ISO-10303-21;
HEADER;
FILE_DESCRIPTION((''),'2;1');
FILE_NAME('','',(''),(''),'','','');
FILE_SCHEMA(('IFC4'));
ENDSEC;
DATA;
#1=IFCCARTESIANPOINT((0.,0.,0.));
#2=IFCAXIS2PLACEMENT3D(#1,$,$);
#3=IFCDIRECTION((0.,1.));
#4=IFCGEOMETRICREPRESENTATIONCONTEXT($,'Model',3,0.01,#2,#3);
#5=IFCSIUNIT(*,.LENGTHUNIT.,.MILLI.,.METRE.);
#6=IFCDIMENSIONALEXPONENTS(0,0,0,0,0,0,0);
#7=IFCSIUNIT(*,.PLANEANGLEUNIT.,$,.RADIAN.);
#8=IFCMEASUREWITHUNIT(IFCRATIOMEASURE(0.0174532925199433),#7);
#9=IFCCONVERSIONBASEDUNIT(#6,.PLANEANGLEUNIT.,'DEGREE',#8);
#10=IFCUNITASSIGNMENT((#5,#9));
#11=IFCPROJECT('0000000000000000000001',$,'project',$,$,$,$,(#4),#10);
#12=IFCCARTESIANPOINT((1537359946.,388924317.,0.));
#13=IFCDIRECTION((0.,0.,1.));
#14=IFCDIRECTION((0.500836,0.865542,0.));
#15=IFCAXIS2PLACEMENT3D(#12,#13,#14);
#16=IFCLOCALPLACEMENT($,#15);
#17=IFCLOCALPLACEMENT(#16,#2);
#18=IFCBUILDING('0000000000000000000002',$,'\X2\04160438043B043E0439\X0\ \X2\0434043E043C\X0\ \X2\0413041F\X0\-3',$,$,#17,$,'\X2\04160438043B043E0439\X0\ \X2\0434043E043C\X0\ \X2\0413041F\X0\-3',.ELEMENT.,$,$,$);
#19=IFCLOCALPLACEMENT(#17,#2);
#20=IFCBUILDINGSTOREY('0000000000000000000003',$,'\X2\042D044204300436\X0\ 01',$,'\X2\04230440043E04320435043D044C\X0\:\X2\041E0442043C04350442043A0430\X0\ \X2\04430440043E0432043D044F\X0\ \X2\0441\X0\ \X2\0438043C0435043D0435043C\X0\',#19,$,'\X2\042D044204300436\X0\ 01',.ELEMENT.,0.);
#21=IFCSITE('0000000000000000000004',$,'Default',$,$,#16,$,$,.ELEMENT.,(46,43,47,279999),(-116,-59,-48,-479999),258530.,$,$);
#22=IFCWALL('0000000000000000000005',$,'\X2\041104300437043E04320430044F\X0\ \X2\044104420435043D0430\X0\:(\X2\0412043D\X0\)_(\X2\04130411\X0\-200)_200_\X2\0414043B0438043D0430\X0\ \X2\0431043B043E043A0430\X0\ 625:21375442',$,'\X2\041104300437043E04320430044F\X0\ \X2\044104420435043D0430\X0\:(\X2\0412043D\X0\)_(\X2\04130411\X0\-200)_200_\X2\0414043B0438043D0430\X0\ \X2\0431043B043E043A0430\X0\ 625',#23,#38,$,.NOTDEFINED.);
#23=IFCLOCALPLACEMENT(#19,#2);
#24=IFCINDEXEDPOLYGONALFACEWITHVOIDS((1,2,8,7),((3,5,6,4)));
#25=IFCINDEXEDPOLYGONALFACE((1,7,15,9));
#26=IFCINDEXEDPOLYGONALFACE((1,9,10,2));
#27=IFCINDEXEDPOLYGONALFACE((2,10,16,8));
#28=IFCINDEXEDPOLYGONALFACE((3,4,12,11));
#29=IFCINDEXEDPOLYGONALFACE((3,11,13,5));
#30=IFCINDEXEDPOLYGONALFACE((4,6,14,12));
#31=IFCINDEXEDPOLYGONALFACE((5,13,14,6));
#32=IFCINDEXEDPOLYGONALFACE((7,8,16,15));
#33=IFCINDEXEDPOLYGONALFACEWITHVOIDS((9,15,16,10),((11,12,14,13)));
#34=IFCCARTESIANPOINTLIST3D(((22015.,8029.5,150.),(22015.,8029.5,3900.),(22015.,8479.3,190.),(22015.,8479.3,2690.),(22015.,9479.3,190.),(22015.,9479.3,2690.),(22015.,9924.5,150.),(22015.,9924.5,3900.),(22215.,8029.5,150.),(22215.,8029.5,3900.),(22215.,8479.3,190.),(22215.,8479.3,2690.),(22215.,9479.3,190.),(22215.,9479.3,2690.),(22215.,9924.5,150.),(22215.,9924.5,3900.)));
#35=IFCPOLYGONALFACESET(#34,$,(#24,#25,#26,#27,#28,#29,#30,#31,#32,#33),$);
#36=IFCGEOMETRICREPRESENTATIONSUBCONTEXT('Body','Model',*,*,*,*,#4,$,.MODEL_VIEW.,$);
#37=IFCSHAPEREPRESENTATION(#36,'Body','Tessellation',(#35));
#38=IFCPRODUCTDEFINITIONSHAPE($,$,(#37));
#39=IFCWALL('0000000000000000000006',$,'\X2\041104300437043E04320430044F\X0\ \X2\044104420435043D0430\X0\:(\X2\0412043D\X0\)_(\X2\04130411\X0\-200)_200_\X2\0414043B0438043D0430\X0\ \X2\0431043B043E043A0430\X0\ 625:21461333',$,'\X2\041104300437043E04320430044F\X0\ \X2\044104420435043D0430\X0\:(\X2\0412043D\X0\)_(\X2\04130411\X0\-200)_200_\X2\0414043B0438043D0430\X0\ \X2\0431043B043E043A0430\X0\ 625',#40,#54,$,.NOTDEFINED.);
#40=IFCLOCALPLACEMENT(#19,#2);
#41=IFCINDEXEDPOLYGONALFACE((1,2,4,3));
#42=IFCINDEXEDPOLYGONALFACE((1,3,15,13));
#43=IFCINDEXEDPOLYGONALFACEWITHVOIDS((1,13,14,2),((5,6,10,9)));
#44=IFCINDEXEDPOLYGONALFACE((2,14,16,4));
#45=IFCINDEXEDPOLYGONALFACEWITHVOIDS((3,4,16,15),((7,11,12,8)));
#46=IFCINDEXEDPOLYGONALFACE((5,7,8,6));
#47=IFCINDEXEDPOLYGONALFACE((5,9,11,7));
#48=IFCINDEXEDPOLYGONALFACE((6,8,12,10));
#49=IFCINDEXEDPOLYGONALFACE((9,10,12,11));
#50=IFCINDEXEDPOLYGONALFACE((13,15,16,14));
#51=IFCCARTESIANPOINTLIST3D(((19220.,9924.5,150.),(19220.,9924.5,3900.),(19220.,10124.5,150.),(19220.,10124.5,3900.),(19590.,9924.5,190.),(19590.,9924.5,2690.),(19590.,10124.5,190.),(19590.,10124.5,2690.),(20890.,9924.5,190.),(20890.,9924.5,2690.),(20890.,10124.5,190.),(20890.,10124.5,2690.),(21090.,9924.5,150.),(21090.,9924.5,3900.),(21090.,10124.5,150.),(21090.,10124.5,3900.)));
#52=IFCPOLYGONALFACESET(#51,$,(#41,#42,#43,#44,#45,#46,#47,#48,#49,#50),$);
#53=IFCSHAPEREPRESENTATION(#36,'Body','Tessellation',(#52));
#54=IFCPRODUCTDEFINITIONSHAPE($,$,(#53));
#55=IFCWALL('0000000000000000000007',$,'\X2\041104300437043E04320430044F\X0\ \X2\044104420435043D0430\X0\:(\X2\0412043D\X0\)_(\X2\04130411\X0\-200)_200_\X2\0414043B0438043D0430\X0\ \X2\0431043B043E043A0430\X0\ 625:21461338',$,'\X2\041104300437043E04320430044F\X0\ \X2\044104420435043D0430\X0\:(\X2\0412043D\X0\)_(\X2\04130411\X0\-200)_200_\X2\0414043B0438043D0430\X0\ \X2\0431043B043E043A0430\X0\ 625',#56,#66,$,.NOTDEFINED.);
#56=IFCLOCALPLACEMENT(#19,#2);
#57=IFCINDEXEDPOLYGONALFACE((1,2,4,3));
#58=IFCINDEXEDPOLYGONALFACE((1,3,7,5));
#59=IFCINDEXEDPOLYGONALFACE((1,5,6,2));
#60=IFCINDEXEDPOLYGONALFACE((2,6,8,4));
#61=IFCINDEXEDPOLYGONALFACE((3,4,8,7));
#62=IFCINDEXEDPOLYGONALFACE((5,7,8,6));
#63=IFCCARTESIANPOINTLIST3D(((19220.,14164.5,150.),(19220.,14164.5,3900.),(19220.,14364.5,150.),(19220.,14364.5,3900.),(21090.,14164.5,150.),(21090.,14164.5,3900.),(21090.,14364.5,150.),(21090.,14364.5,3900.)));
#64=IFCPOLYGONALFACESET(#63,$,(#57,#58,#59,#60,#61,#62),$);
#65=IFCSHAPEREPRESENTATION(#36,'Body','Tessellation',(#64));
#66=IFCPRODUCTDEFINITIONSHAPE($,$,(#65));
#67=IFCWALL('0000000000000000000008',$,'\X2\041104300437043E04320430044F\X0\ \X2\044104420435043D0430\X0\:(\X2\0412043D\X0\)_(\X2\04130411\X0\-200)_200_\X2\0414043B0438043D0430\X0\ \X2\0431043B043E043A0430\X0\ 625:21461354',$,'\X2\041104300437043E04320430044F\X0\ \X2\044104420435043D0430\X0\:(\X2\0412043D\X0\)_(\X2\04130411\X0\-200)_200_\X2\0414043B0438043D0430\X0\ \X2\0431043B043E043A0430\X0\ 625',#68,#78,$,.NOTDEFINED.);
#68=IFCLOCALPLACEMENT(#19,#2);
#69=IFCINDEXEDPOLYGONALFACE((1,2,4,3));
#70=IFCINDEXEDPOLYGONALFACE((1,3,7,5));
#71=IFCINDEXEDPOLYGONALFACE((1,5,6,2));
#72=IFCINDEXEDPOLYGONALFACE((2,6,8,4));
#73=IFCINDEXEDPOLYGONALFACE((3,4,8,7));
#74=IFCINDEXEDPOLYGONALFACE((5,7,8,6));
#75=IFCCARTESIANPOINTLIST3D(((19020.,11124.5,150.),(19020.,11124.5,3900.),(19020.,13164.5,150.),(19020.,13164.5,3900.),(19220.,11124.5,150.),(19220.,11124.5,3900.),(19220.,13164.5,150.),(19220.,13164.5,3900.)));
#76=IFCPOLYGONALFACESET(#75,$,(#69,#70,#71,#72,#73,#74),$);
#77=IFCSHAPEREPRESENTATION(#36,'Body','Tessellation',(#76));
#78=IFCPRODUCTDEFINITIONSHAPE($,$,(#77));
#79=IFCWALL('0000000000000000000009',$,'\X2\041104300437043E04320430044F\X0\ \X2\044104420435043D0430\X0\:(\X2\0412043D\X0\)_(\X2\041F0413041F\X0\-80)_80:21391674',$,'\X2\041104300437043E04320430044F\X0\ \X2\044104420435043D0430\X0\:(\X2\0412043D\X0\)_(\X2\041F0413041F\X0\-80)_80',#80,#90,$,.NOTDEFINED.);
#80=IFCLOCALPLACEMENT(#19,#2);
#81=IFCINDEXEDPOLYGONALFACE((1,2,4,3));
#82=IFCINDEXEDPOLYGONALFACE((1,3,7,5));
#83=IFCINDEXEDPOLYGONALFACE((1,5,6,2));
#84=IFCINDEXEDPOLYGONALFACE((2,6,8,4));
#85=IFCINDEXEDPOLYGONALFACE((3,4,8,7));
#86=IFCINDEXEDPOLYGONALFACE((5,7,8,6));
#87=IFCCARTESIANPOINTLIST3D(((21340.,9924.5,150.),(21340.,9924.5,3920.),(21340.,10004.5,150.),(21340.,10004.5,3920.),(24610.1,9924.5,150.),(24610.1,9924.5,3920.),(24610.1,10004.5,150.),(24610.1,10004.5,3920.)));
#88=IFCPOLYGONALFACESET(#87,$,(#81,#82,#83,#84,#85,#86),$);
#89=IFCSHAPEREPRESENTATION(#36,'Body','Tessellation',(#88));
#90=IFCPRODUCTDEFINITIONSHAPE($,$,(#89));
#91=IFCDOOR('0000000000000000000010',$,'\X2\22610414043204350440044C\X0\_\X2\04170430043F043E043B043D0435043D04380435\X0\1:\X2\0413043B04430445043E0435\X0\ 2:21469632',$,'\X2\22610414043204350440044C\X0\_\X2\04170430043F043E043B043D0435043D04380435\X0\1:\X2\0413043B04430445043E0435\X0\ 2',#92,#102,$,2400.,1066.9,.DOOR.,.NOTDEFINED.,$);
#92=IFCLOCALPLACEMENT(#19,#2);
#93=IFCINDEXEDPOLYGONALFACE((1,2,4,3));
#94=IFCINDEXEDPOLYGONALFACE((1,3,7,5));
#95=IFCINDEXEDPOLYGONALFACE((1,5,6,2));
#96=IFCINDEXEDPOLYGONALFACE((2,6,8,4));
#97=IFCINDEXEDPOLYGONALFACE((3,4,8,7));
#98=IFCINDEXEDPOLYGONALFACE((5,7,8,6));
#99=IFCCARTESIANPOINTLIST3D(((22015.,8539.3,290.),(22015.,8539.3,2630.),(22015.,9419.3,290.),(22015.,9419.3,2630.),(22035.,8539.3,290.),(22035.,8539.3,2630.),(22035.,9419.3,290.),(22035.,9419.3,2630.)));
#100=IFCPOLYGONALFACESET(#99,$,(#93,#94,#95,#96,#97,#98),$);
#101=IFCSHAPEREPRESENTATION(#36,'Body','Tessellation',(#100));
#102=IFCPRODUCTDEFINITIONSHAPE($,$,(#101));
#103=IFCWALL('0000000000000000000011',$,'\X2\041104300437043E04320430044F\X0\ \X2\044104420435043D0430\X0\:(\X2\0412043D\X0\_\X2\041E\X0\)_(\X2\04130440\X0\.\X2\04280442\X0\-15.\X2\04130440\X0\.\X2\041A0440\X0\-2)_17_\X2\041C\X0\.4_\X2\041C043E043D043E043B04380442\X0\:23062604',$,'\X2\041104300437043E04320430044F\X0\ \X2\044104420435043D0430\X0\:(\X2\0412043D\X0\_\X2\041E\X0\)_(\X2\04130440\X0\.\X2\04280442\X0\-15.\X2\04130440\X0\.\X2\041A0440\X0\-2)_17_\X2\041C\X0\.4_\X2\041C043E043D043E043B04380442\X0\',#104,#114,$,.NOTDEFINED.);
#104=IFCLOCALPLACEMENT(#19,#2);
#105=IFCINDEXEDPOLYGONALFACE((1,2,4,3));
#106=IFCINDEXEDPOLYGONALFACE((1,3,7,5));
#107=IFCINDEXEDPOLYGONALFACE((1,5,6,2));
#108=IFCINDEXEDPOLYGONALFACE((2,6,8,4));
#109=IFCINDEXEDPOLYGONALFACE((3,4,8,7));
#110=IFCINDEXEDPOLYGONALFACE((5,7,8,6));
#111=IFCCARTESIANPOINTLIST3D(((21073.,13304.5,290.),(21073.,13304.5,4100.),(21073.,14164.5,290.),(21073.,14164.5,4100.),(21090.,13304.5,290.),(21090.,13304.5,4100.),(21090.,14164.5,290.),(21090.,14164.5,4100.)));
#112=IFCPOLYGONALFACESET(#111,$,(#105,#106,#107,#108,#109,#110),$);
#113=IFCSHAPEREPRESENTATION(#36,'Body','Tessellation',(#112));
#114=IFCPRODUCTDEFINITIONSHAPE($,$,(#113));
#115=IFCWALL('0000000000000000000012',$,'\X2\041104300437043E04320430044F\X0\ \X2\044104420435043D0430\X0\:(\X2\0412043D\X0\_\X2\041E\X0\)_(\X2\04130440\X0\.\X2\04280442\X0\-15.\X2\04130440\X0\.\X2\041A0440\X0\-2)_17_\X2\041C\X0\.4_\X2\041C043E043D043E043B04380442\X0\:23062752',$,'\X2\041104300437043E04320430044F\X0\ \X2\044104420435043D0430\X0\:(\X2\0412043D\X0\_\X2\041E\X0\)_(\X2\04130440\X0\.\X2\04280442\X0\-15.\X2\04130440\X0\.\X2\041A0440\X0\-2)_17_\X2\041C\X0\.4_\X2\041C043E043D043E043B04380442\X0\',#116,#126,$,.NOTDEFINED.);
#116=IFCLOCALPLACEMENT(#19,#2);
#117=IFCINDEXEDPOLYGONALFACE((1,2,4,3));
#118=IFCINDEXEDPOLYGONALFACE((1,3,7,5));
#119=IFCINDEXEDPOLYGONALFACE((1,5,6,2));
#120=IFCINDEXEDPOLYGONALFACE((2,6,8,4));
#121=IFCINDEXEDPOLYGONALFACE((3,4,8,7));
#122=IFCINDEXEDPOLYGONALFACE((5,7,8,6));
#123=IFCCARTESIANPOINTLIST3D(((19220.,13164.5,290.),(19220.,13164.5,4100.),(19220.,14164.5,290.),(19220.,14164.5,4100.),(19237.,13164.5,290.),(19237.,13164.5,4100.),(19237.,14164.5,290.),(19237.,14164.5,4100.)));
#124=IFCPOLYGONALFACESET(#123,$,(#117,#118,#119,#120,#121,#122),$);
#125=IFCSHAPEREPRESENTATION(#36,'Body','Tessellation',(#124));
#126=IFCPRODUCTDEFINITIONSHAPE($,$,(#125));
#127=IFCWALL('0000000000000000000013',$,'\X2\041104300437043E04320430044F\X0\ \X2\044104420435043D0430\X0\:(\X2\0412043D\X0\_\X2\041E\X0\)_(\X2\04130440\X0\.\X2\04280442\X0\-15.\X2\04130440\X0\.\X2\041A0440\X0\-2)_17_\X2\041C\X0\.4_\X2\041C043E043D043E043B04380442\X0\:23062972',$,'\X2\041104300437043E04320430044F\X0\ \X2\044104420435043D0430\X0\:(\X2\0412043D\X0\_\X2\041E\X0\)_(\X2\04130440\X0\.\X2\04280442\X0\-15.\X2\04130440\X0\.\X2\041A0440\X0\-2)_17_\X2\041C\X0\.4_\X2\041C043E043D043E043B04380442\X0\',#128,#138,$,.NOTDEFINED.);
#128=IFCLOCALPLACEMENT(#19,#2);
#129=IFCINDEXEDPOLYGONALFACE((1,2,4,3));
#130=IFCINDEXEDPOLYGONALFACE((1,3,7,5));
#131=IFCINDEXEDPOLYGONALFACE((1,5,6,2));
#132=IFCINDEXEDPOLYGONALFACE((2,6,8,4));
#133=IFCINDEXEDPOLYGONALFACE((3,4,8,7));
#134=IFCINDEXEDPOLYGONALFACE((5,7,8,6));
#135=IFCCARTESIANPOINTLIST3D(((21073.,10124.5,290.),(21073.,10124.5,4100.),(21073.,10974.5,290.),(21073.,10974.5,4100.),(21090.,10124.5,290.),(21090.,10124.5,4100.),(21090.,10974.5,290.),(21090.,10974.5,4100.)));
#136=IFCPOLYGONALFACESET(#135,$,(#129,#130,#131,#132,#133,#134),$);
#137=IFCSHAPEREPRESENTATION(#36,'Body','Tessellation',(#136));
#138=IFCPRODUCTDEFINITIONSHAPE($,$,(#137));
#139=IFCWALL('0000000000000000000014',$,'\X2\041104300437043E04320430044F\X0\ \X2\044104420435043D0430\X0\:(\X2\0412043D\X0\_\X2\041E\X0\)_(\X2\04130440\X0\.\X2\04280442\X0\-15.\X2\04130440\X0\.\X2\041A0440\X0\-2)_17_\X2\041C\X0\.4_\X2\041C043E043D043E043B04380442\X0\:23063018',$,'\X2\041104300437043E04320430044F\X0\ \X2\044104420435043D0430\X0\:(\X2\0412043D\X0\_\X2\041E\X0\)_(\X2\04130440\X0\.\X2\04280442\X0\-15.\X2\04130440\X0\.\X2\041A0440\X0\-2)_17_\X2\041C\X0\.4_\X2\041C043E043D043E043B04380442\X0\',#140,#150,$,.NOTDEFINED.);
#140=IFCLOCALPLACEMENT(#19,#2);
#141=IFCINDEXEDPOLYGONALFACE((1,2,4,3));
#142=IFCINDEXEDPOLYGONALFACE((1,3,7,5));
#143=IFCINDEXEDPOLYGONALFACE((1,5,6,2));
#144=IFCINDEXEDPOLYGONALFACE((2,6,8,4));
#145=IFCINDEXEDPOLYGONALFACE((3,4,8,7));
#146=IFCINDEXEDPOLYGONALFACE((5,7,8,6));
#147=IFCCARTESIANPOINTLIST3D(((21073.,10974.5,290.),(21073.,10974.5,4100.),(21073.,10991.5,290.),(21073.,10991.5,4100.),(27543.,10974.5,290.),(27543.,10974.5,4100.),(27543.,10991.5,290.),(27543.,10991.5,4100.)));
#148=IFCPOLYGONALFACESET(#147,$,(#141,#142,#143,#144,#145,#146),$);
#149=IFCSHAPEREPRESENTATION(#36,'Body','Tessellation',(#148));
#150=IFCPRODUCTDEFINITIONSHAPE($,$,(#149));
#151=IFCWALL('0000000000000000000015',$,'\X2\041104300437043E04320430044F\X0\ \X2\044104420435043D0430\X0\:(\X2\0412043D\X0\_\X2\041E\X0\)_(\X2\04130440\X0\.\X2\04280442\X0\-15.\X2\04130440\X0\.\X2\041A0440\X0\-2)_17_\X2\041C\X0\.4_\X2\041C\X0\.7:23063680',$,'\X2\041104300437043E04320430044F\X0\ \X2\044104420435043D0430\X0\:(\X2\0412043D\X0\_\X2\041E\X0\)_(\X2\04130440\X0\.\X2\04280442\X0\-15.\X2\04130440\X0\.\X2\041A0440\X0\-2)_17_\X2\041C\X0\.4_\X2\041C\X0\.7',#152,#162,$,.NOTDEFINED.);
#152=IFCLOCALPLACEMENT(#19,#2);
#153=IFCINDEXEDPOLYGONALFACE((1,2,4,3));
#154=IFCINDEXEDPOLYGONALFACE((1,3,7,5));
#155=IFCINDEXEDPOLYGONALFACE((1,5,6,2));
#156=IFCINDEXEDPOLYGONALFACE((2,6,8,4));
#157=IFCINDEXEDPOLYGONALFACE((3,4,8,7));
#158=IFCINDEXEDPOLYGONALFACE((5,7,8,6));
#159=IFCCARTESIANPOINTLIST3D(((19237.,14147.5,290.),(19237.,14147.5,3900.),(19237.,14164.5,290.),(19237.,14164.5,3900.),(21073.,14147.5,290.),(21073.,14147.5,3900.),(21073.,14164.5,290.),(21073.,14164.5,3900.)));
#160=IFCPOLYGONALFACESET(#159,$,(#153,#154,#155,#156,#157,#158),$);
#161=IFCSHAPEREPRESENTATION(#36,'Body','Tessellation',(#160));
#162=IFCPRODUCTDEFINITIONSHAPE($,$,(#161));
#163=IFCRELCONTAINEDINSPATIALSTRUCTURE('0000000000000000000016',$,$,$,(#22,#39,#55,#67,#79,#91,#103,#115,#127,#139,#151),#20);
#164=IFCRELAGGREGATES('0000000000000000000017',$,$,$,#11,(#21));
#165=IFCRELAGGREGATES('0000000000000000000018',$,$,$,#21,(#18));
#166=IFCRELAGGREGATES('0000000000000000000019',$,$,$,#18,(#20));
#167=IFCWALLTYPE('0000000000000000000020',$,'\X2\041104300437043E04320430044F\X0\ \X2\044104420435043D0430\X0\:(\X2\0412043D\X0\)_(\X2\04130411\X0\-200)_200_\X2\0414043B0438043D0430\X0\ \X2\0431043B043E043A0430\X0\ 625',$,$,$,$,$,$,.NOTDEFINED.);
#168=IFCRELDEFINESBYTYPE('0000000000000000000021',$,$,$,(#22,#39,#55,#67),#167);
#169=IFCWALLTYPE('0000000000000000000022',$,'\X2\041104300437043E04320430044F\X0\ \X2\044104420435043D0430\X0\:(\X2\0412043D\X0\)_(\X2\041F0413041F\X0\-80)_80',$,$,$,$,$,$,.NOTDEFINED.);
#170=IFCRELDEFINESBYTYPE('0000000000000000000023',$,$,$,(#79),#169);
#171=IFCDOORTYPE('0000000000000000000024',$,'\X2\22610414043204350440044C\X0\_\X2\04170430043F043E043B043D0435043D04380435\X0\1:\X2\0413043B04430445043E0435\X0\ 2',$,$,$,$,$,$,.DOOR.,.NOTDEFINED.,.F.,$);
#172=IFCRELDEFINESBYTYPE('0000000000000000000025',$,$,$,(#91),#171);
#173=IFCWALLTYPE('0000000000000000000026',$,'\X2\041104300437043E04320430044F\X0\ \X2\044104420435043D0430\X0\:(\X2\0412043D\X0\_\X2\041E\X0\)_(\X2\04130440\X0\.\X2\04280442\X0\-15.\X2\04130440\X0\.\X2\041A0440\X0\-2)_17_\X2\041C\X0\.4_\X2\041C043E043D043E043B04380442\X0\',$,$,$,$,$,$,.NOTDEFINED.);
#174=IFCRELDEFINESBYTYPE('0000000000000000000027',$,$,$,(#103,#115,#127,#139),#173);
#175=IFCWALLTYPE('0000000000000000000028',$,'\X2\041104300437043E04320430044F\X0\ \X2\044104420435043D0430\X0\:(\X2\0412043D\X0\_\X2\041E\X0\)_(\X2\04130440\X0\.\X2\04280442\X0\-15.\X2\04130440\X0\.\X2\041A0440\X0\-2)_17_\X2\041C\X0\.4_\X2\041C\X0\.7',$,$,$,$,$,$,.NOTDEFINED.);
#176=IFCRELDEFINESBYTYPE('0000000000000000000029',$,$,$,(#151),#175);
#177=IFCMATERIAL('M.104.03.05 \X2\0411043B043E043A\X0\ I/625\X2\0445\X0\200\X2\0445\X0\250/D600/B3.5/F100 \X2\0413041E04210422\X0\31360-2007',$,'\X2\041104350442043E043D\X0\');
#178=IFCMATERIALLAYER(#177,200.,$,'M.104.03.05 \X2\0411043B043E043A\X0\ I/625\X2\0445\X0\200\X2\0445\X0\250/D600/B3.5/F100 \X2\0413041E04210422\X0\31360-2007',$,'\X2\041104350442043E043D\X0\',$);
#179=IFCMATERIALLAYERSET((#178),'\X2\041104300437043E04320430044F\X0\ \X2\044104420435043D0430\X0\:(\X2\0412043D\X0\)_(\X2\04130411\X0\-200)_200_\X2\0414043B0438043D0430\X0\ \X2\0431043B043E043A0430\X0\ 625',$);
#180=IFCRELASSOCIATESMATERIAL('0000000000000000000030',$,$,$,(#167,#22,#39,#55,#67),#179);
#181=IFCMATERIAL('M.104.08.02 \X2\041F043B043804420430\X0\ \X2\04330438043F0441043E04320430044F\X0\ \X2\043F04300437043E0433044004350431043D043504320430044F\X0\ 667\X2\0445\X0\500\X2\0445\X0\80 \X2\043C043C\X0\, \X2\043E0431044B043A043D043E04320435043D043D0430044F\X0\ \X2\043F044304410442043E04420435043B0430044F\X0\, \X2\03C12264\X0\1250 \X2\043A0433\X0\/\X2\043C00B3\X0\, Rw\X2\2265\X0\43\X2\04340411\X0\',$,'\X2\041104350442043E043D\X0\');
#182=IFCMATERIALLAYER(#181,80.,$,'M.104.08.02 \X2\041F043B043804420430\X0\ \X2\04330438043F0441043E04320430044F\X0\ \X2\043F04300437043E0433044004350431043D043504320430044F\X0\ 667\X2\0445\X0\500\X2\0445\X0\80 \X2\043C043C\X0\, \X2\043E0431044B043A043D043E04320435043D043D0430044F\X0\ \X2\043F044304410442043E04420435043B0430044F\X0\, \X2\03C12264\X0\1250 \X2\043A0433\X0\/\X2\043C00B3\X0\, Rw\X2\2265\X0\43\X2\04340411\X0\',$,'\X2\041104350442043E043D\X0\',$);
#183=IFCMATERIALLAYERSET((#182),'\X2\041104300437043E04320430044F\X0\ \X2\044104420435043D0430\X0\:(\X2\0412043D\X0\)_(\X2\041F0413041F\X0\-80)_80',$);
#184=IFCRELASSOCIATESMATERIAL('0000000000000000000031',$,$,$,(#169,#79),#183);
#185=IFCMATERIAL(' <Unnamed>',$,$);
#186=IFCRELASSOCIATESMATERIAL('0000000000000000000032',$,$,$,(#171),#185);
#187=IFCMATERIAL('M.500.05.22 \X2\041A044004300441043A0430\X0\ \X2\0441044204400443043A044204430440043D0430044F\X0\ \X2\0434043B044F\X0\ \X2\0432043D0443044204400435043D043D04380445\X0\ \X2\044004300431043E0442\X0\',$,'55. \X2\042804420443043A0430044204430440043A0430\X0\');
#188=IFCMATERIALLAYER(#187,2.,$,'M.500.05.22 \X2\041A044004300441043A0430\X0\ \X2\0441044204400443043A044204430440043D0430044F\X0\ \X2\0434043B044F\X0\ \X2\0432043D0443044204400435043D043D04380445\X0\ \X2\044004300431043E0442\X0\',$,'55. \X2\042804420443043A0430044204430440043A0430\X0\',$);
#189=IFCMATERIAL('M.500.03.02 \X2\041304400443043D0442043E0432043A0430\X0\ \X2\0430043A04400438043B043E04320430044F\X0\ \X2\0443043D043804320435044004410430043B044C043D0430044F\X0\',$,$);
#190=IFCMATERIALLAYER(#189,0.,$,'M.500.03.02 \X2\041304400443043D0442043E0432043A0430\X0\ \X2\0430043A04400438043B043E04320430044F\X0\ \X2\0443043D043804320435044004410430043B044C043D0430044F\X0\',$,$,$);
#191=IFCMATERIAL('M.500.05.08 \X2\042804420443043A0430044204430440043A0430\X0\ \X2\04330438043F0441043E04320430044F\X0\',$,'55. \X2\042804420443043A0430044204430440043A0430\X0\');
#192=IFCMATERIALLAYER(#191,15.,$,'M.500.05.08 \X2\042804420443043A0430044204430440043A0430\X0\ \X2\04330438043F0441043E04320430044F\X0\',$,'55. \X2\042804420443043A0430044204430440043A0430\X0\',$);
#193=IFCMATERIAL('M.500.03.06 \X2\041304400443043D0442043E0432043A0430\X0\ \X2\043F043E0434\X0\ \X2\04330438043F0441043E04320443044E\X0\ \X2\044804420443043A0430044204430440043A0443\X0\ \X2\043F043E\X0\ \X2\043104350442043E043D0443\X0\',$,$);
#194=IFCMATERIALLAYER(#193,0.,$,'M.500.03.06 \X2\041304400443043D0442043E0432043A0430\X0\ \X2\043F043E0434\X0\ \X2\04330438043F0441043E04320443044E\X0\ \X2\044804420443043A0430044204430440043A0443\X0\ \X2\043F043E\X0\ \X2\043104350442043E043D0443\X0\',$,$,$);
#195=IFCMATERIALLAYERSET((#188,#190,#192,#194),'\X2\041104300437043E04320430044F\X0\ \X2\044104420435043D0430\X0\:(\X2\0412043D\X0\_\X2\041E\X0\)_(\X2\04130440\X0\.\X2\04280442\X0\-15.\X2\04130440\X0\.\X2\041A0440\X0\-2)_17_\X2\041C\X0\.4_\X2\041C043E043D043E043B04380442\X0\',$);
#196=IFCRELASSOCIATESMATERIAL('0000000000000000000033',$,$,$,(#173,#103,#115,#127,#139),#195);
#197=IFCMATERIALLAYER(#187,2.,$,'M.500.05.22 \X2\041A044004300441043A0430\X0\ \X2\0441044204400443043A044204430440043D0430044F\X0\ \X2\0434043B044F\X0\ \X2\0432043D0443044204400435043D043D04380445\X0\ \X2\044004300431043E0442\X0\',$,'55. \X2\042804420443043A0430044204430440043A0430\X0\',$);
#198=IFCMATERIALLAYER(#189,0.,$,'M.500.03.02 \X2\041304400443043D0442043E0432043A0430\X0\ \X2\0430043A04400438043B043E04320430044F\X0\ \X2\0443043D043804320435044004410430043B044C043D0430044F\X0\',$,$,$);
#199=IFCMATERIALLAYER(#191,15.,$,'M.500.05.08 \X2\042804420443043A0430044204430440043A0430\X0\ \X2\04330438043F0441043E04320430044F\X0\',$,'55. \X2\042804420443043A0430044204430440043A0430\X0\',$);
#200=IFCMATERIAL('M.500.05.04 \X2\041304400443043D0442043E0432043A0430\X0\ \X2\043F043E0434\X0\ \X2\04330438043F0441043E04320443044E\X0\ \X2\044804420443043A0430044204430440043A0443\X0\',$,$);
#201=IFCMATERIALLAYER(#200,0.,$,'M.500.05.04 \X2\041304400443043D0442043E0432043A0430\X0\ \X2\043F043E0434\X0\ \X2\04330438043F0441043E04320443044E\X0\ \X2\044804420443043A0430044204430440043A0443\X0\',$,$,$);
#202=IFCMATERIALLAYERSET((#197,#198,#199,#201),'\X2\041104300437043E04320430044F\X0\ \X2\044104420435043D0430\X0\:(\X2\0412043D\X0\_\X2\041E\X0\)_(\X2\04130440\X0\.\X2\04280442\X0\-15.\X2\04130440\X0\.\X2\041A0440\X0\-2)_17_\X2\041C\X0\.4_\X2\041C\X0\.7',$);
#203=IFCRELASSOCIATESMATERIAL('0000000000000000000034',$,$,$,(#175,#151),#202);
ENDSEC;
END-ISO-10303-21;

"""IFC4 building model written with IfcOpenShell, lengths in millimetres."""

from ifc_helpers import new_model, entity, si_unit, converted_unit, direction, frame, frame_2d, origin, origin_2d_with_axis, place, context, subcontext, project, spatial, rectangle, extrude, source, transform, mapped, material, layer, layer_set, layer_usage, type_object, type_shapes, element, save


model = new_model("IFC4")

# Units and contexts
model_context = context("Model", 3, precision=0.01, world=origin(), true_north=direction((0.0, 1.0)))
body_context = subcontext(model_context, "Body", "Model", "MODEL_VIEW")
ifc_project = project(units=[si_unit("LENGTHUNIT", "METRE", prefix="MILLI"), converted_unit("PLANEANGLEUNIT", "DEGREE", entity("IfcRatioMeasure", 0.0174532925199433), si_unit("PLANEANGLEUNIT", "RADIAN"), dimensions=[0, 0, 0, 0, 0, 0, 0])], contexts=[model_context])

# Site, building, storey
site_placement = place(None, frame((1537359946.0, 388924317.0, 0.0), z_axis=(0.0, 0.0, 1.0), x_axis=(0.500836, 0.865542, 0.0)))
site = spatial("IfcSite", under=ifc_project, at=site_placement, Name="Default", CompositionType="ELEMENT", RefLatitude=(46, 43, 47, 279999), RefLongitude=(-116, -59, -48, -479999), RefElevation=258530.0)
building_placement = place(site_placement, origin())
building = spatial("IfcBuilding", under=site, at=building_placement, Name="Жилой дом ГП-3", LongName="Жилой дом ГП-3", CompositionType="ELEMENT")
storey_placement = place(building_placement, origin())
storey = spatial("IfcBuildingStorey", under=building, at=storey_placement, Name="Этаж 01", ObjectType="Уровень:Отметка уровня с именем", LongName="Этаж 01", CompositionType="ELEMENT", Elevation=0.0)

# Walls, openings
ifc_material_1 = material(Name="M.104.03.05 Блок I/625х200х250/D600/B3.5/F100 ГОСТ31360-2007", Category="Бетон")
ifc_layer_1 = layer(ifc_material_1, 200.0, Name="M.104.03.05 Блок I/625х200х250/D600/B3.5/F100 ГОСТ31360-2007", Category="Бетон")
ifc_layer_set_1 = layer_set([ifc_layer_1], Name="Базовая стена:(Вн)_(ГБ-200)_200_Длина блока 625")
ifc_layer_usage_1 = layer_usage(ifc_layer_set_1, "AXIS2", "POSITIVE", -100.0)
wall_type_1 = type_object("IfcWallType", Name="Базовая стена:(Вн)_(ГБ-200)_200_Длина блока 625", PredefinedType="NOTDEFINED", material=ifc_layer_set_1)
wall_1_placement = place(storey_placement, frame((22115.0, 9924.5, 150.0), z_axis=(0.0, 0.0, 1.0), x_axis=(0.0, -1.0, 0.0)))
wall_1 = element("IfcWall", 1, at=wall_1_placement, inside=storey, type_object=wall_type_1, material=ifc_layer_usage_1, Name="Базовая стена:(Вн)_(ГБ-200)_200_Длина блока 625:21375442", ObjectType="Базовая стена:(Вн)_(ГБ-200)_200_Длина блока 625", PredefinedType="NOTDEFINED", context=body_context, shape_type="SweptSolid", body=[
    extrude(rectangle(XDim=1895.0, YDim=200.0, at=frame_2d((947.5, 0.0), x_axis=(-1.0, 0.0))), origin(), (0.0, 0.0, 1.0), 3750.0),
])
opening_1_placement = place(wall_1_placement, frame((1445.3, -300.0, 40.0), z_axis=(0.0, 0.0, 1.0), x_axis=(0.0, 1.0, 0.0)))
element("IfcOpeningElement", 2, at=opening_1_placement, cuts=wall_1, ObjectType="Opening", PredefinedType="OPENING", context=body_context, shape_type="SweptSolid", body=[
    extrude(rectangle(XDim=2500.0, YDim=1000.0, at=frame_2d((0.0, 0.0), x_axis=(1.0, 0.0))), frame((0.0, 500.0, 1250.0), z_axis=(1.0, 0.0, 0.0), x_axis=(0.0, 0.0, -1.0)), (0.0, 0.0, 1.0), 600.0),
])
ifc_layer_usage_2 = layer_usage(ifc_layer_set_1, "AXIS2", "POSITIVE", -100.0)
wall_2_placement = place(storey_placement, frame((21090.0, 10024.5, 150.0), z_axis=(0.0, 0.0, 1.0), x_axis=(-1.0, 0.0, 0.0)))
wall_2 = element("IfcWall", 3, at=wall_2_placement, inside=storey, type_object=wall_type_1, material=ifc_layer_usage_2, Name="Базовая стена:(Вн)_(ГБ-200)_200_Длина блока 625:21461333", ObjectType="Базовая стена:(Вн)_(ГБ-200)_200_Длина блока 625", PredefinedType="NOTDEFINED", context=body_context, shape_type="SweptSolid", body=[
    extrude(rectangle(XDim=1870.0, YDim=200.0, at=frame_2d((935.0, 0.0), x_axis=(-1.0, 0.0))), origin(), (0.0, 0.0, 1.0), 3750.0),
])
opening_2_placement = place(wall_2_placement, frame((1500.0, 300.0, 40.0), z_axis=(0.0, 0.0, 1.0), x_axis=(-1.0, 0.0, 0.0)))
element("IfcOpeningElement", 4, at=opening_2_placement, cuts=wall_2, ObjectType="Opening", PredefinedType="OPENING", context=body_context, shape_type="SweptSolid", body=[
    extrude(rectangle(XDim=2500.0, YDim=1300.0, at=frame_2d((0.0, 0.0), x_axis=(0.0, 1.0))), frame((650.0, 600.0, 1250.0), z_axis=(0.0, -1.0, 0.0), x_axis=(-1.0, 0.0, 0.0)), (0.0, 0.0, 1.0), 600.0),
])

# Walls
ifc_layer_usage_3 = layer_usage(ifc_layer_set_1, "AXIS2", "NEGATIVE", 100.0)
wall_3_placement = place(storey_placement, frame((21090.0, 14264.5, 150.0), z_axis=(0.0, 0.0, 1.0), x_axis=(-1.0, 0.0, 0.0)))
element("IfcWall", 5, at=wall_3_placement, inside=storey, type_object=wall_type_1, material=ifc_layer_usage_3, Name="Базовая стена:(Вн)_(ГБ-200)_200_Длина блока 625:21461338", ObjectType="Базовая стена:(Вн)_(ГБ-200)_200_Длина блока 625", PredefinedType="NOTDEFINED", context=body_context, shape_type="SweptSolid", body=[
    extrude(rectangle(XDim=1870.0, YDim=200.0, at=frame_2d((935.0, 0.0), x_axis=(-1.0, 0.0))), origin(), (0.0, 0.0, 1.0), 3750.0),
])
ifc_layer_usage_4 = layer_usage(ifc_layer_set_1, "AXIS2", "NEGATIVE", 100.0)
wall_4_placement = place(storey_placement, frame((19120.0, 13164.5, 150.0), z_axis=(0.0, 0.0, 1.0), x_axis=(0.0, -1.0, 0.0)))
element("IfcWall", 6, at=wall_4_placement, inside=storey, type_object=wall_type_1, material=ifc_layer_usage_4, Name="Базовая стена:(Вн)_(ГБ-200)_200_Длина блока 625:21461354", ObjectType="Базовая стена:(Вн)_(ГБ-200)_200_Длина блока 625", PredefinedType="NOTDEFINED", context=body_context, shape_type="SweptSolid", body=[
    extrude(rectangle(XDim=2040.0, YDim=200.0, at=frame_2d((1020.0, 0.0), x_axis=(-1.0, 0.0))), origin(), (0.0, 0.0, 1.0), 3750.0),
])
ifc_material_2 = material(Name="M.104.08.02 Плита гипсовая пазогребневая 667х500х80 мм, обыкновенная пустотелая, ρ≤1250 кг/м³, Rw≥43дБ", Category="Бетон")
ifc_layer_2 = layer(ifc_material_2, 80.0, Name="M.104.08.02 Плита гипсовая пазогребневая 667х500х80 мм, обыкновенная пустотелая, ρ≤1250 кг/м³, Rw≥43дБ", Category="Бетон")
ifc_layer_set_2 = layer_set([ifc_layer_2], Name="Базовая стена:(Вн)_(ПГП-80)_80")
ifc_layer_usage_5 = layer_usage(ifc_layer_set_2, "AXIS2", "POSITIVE", -40.0)
wall_type_2 = type_object("IfcWallType", Name="Базовая стена:(Вн)_(ПГП-80)_80", PredefinedType="NOTDEFINED", material=ifc_layer_set_2)
wall_5_placement = place(storey_placement, frame((21340.0, 9964.5, 150.0)))
element("IfcWall", 7, at=wall_5_placement, inside=storey, type_object=wall_type_2, material=ifc_layer_usage_5, Name="Базовая стена:(Вн)_(ПГП-80)_80:21391674", ObjectType="Базовая стена:(Вн)_(ПГП-80)_80", PredefinedType="NOTDEFINED", context=body_context, shape_type="SweptSolid", body=[
    extrude(rectangle(XDim=3270.1, YDim=80.0, at=frame_2d((1635.1, 0.0), x_axis=(-1.0, 0.0))), origin(), (0.0, 0.0, 1.0), 3770.0),
])

# Door
ifc_material_3 = material(Name=" <Unnamed>")
door_type = type_object("IfcDoorType", Name="≡Дверь_Заполнение1:Глухое 2", OperationType="NOTDEFINED", ParameterTakesPrecedence=False, PredefinedType="DOOR", material=ifc_material_3)
shared_shape_1 = source(origin(), body_context, "Body", "SweptSolid", [
    extrude(rectangle(XDim=20.0, YDim=880.0, at=origin_2d_with_axis()), frame((0.0, -10.0, 0.0), z_axis=(0.0, 0.0, 1.0), x_axis=(0.0, 1.0, 0.0)), (0.0, 0.0, 1.0), 2340.0),
])
type_shapes(door_type, [shared_shape_1])
door_placement = place(storey_placement, frame((22015.0, 8979.3, 290.0), z_axis=(0.0, 0.0, 1.0), x_axis=(0.0, 1.0, 0.0)))
element("IfcDoor", 8, at=door_placement, inside=storey, type_object=door_type, Name="≡Дверь_Заполнение1:Глухое 2:21469632", ObjectType="≡Дверь_Заполнение1:Глухое 2", OperationType="NOTDEFINED", OverallHeight=2400.0, OverallWidth=1066.9, PredefinedType="DOOR", context=body_context, shape_type="MappedRepresentation", body=[
    mapped(shared_shape_1, transform((0.0, 0.0, 0.0), scale=1.0)),
])

# Shared definitions
ifc_material_4 = material(Name="M.500.03.02 Грунтовка акриловая универсальная")
ifc_material_5 = material(Name="M.500.05.22 Краска структурная для внутренних работ", Category="55. Штукатурка")

# Walls
ifc_layer_3 = layer(ifc_material_5, 2.0, Name="M.500.05.22 Краска структурная для внутренних работ", Category="55. Штукатурка")
ifc_layer_4 = layer(ifc_material_4, 0.0, Name="M.500.03.02 Грунтовка акриловая универсальная")
ifc_material_6 = material(Name="M.500.05.08 Штукатурка гипсовая", Category="55. Штукатурка")
ifc_layer_5 = layer(ifc_material_6, 15.0, Name="M.500.05.08 Штукатурка гипсовая", Category="55. Штукатурка")
ifc_material_7 = material(Name="M.500.03.06 Грунтовка под гипсовую штукатурку по бетону")
ifc_layer_6 = layer(ifc_material_7, 0.0, Name="M.500.03.06 Грунтовка под гипсовую штукатурку по бетону")
ifc_layer_set_3 = layer_set([ifc_layer_3, ifc_layer_4, ifc_layer_5, ifc_layer_6], Name="Базовая стена:(Вн_О)_(Гр.Шт-15.Гр.Кр-2)_17_М.4_Монолит")
ifc_layer_usage_6 = layer_usage(ifc_layer_set_3, "AXIS2", "NEGATIVE", 8.5)
wall_type_3 = type_object("IfcWallType", Name="Базовая стена:(Вн_О)_(Гр.Шт-15.Гр.Кр-2)_17_М.4_Монолит", PredefinedType="NOTDEFINED", material=ifc_layer_set_3)
wall_6_placement = place(storey_placement, frame((21081.5, 13304.5, 290.0), z_axis=(0.0, 0.0, 1.0), x_axis=(0.0, 1.0, 0.0)))
element("IfcWall", 9, at=wall_6_placement, inside=storey, type_object=wall_type_3, material=ifc_layer_usage_6, Name="Базовая стена:(Вн_О)_(Гр.Шт-15.Гр.Кр-2)_17_М.4_Монолит:23062604", ObjectType="Базовая стена:(Вн_О)_(Гр.Шт-15.Гр.Кр-2)_17_М.4_Монолит", PredefinedType="NOTDEFINED", context=body_context, shape_type="SweptSolid", body=[
    extrude(rectangle(XDim=860.0, YDim=17.0, at=frame_2d((430.0, 0.0), x_axis=(-1.0, 0.0))), origin(), (0.0, 0.0, 1.0), 3810.0),
])
ifc_layer_usage_7 = layer_usage(ifc_layer_set_3, "AXIS2", "NEGATIVE", 8.5)
wall_7_placement = place(storey_placement, frame((19228.5, 14164.5, 290.0), z_axis=(0.0, 0.0, 1.0), x_axis=(0.0, -1.0, 0.0)))
element("IfcWall", 10, at=wall_7_placement, inside=storey, type_object=wall_type_3, material=ifc_layer_usage_7, Name="Базовая стена:(Вн_О)_(Гр.Шт-15.Гр.Кр-2)_17_М.4_Монолит:23062752", ObjectType="Базовая стена:(Вн_О)_(Гр.Шт-15.Гр.Кр-2)_17_М.4_Монолит", PredefinedType="NOTDEFINED", context=body_context, shape_type="SweptSolid", body=[
    extrude(rectangle(XDim=1000.0, YDim=17.0, at=frame_2d((500.0, 0.0), x_axis=(-1.0, 0.0))), origin(), (0.0, 0.0, 1.0), 3810.0),
])
ifc_layer_usage_8 = layer_usage(ifc_layer_set_3, "AXIS2", "NEGATIVE", 8.5)
wall_8_placement = place(storey_placement, frame((21081.5, 10124.5, 290.0), z_axis=(0.0, 0.0, 1.0), x_axis=(0.0, 1.0, 0.0)))
element("IfcWall", 11, at=wall_8_placement, inside=storey, type_object=wall_type_3, material=ifc_layer_usage_8, Name="Базовая стена:(Вн_О)_(Гр.Шт-15.Гр.Кр-2)_17_М.4_Монолит:23062972", ObjectType="Базовая стена:(Вн_О)_(Гр.Шт-15.Гр.Кр-2)_17_М.4_Монолит", PredefinedType="NOTDEFINED", context=body_context, shape_type="SweptSolid", body=[
    extrude(rectangle(XDim=850.0, YDim=17.0, at=frame_2d((425.0, 0.0), x_axis=(-1.0, 0.0))), origin(), (0.0, 0.0, 1.0), 3810.0),
])
ifc_layer_usage_9 = layer_usage(ifc_layer_set_3, "AXIS2", "NEGATIVE", 8.5)
wall_9_placement = place(storey_placement, frame((21073.0, 10983.0, 290.0)))
element("IfcWall", 12, at=wall_9_placement, inside=storey, type_object=wall_type_3, material=ifc_layer_usage_9, Name="Базовая стена:(Вн_О)_(Гр.Шт-15.Гр.Кр-2)_17_М.4_Монолит:23063018", ObjectType="Базовая стена:(Вн_О)_(Гр.Шт-15.Гр.Кр-2)_17_М.4_Монолит", PredefinedType="NOTDEFINED", context=body_context, shape_type="SweptSolid", body=[
    extrude(rectangle(XDim=6470.0, YDim=17.0, at=frame_2d((3235.0, 0.0), x_axis=(-1.0, 0.0))), origin(), (0.0, 0.0, 1.0), 3810.0),
])
ifc_layer_7 = layer(ifc_material_5, 2.0, Name="M.500.05.22 Краска структурная для внутренних работ", Category="55. Штукатурка")
ifc_layer_8 = layer(ifc_material_4, 0.0, Name="M.500.03.02 Грунтовка акриловая универсальная")
ifc_layer_9 = layer(ifc_material_6, 15.0, Name="M.500.05.08 Штукатурка гипсовая", Category="55. Штукатурка")
ifc_material_8 = material(Name="M.500.05.04 Грунтовка под гипсовую штукатурку")
ifc_layer_10 = layer(ifc_material_8, 0.0, Name="M.500.05.04 Грунтовка под гипсовую штукатурку")
ifc_layer_set_4 = layer_set([ifc_layer_7, ifc_layer_8, ifc_layer_9, ifc_layer_10], Name="Базовая стена:(Вн_О)_(Гр.Шт-15.Гр.Кр-2)_17_М.4_М.7")
ifc_layer_usage_10 = layer_usage(ifc_layer_set_4, "AXIS2", "NEGATIVE", 8.5)
wall_type_4 = type_object("IfcWallType", Name="Базовая стена:(Вн_О)_(Гр.Шт-15.Гр.Кр-2)_17_М.4_М.7", PredefinedType="NOTDEFINED", material=ifc_layer_set_4)
wall_10_placement = place(storey_placement, frame((21073.0, 14156.0, 290.0), z_axis=(0.0, 0.0, 1.0), x_axis=(-1.0, 0.0, 0.0)))
element("IfcWall", 13, at=wall_10_placement, inside=storey, type_object=wall_type_4, material=ifc_layer_usage_10, Name="Базовая стена:(Вн_О)_(Гр.Шт-15.Гр.Кр-2)_17_М.4_М.7:23063680", ObjectType="Базовая стена:(Вн_О)_(Гр.Шт-15.Гр.Кр-2)_17_М.4_М.7", PredefinedType="NOTDEFINED", context=body_context, shape_type="SweptSolid", body=[
    extrude(rectangle(XDim=1836.0, YDim=17.0, at=frame_2d((918.0, 0.0), x_axis=(-1.0, 0.0))), origin(), (0.0, 0.0, 1.0), 3610.0),
])

save(model, "model.ifc")
